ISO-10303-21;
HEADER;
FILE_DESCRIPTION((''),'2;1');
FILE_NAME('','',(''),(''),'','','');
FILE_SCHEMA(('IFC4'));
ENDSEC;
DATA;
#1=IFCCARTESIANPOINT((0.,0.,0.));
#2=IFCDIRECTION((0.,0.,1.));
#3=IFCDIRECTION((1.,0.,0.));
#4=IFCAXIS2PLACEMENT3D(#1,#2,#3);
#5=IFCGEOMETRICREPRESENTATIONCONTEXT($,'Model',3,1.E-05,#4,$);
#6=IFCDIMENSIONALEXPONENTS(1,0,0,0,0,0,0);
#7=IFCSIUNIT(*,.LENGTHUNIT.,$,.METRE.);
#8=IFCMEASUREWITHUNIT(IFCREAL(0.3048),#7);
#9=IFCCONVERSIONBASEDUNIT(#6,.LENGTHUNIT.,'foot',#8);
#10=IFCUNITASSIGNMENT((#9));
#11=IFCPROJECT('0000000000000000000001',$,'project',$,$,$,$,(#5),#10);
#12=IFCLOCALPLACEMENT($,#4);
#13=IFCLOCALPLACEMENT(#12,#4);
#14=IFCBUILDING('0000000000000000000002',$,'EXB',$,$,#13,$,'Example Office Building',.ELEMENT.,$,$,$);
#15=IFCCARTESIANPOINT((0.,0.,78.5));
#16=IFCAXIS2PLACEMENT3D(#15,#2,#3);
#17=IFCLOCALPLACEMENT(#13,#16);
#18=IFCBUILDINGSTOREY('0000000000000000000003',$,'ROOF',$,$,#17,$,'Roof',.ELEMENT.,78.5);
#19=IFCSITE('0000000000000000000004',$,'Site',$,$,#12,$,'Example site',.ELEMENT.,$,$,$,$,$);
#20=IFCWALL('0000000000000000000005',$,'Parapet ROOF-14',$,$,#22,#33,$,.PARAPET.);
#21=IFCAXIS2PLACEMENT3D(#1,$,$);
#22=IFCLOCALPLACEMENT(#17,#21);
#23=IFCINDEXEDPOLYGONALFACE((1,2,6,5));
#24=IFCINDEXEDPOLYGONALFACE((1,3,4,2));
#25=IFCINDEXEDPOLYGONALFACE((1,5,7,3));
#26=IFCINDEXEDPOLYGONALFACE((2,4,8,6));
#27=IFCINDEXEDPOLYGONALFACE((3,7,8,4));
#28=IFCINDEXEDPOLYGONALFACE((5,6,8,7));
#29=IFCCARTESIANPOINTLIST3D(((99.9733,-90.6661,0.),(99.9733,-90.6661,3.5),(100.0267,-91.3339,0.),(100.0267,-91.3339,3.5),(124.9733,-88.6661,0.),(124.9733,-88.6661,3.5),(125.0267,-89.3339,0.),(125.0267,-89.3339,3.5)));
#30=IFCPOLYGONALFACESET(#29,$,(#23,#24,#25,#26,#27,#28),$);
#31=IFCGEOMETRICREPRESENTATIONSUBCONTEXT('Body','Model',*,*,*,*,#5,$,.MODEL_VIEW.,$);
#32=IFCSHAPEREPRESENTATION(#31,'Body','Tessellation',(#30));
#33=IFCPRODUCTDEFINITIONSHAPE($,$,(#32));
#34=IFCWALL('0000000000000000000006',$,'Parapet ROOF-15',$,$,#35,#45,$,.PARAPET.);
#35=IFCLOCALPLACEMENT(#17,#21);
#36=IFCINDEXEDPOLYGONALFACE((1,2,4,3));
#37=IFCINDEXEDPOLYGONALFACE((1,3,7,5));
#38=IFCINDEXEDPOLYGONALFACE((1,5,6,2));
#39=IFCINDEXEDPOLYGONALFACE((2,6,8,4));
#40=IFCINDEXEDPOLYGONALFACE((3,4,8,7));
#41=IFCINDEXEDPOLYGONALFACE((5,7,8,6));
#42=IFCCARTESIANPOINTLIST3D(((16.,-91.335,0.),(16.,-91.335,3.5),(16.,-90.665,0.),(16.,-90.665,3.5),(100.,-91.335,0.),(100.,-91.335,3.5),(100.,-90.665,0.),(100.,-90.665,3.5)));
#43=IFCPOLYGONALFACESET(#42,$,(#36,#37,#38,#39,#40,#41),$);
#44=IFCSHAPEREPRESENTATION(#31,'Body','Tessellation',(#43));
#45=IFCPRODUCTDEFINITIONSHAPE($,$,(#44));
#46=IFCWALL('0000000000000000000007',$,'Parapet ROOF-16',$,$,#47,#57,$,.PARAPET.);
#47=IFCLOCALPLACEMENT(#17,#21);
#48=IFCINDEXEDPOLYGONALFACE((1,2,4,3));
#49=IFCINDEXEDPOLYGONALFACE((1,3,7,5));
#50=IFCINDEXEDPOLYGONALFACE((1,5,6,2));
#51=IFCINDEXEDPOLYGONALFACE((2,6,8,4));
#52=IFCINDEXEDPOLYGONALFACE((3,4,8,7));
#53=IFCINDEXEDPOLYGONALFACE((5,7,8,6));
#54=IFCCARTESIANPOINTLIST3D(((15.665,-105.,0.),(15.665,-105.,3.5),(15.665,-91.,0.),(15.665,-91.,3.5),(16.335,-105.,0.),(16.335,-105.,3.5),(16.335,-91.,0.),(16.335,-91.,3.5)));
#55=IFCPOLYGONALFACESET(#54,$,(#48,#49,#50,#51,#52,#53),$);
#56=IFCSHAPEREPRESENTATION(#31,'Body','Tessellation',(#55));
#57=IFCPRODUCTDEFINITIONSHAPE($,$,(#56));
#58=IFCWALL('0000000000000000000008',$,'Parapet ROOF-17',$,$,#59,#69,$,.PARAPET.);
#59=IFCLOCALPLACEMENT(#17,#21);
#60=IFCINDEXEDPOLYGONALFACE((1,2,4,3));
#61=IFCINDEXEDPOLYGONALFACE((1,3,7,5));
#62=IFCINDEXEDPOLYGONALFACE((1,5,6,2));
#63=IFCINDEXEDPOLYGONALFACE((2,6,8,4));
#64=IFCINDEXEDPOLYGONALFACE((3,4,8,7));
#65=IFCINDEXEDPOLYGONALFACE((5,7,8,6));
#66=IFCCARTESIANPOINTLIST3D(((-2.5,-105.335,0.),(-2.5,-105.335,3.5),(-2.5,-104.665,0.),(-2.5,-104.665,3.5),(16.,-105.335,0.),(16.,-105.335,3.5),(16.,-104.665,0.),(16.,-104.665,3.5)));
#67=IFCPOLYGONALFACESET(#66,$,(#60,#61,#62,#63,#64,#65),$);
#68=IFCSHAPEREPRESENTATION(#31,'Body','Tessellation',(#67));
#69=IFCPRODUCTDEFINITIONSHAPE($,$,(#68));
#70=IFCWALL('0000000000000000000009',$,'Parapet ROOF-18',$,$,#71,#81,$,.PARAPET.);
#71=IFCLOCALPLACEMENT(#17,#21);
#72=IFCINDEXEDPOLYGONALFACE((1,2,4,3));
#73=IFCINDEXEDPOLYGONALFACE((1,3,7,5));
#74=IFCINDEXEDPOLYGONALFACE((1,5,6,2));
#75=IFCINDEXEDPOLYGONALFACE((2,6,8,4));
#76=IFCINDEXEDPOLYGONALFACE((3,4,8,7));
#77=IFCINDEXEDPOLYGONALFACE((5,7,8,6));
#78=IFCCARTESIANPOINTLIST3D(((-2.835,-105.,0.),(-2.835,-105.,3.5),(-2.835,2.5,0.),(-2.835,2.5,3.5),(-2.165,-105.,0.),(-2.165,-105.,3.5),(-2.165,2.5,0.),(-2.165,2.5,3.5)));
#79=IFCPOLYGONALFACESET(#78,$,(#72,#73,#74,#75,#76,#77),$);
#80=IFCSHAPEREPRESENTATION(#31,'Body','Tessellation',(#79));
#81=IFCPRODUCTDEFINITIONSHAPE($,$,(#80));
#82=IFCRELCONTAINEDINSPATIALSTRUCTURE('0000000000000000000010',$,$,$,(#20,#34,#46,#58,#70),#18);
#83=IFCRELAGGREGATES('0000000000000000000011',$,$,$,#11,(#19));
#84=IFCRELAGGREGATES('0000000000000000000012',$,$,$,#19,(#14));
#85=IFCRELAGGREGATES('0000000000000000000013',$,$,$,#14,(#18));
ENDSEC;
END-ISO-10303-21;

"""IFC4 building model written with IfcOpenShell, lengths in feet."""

from ifc_helpers import new_model, entity, si_unit, converted_unit, frame, frame_2d, origin, origin_with_axes, place, context, subcontext, project, spatial, rectangle, extrude, element, save


model = new_model("IFC4")

# Units and contexts
model_context = context("Model", 3, precision=1e-05, world=origin_with_axes())
body_context = subcontext(model_context, "Body", "Model", "MODEL_VIEW")
ifc_project = project(units=[converted_unit("LENGTHUNIT", "foot", entity("IfcReal", 0.3048), si_unit("LENGTHUNIT", "METRE"), dimensions=[1, 0, 0, 0, 0, 0, 0])], contexts=[model_context])

# Site, building, storey
site_placement = place(None, origin_with_axes())
site = spatial("IfcSite", under=ifc_project, at=site_placement, Name="Site", LongName="Example site", CompositionType="ELEMENT")
building_placement = place(site_placement, origin_with_axes())
building = spatial("IfcBuilding", under=site, at=building_placement, Name="EXB", LongName="Example Office Building", CompositionType="ELEMENT")
storey_placement = place(building_placement, frame((0.0, 0.0, 78.5), z_axis=(0.0, 0.0, 1.0), x_axis=(1.0, 0.0, 0.0)))
storey = spatial("IfcBuildingStorey", under=building, at=storey_placement, Name="ROOF", LongName="Roof", CompositionType="ELEMENT", Elevation=78.5)

# Walls
wall_1_placement = place(storey_placement, frame((125.0, -89.0, 0.0), z_axis=(0.0, 0.0, 1.0), x_axis=(-0.996815, -0.079745, 0.0)))
element("IfcWall", 1, at=wall_1_placement, inside=storey, Name="Parapet ROOF-14", PredefinedType="PARAPET", context=body_context, shape_type="SweptSolid", body=[
    extrude(rectangle(XDim=25.0799, YDim=0.67, at=frame_2d((12.5399, 0.0))), origin(), (0.0, 0.0, 1.0), 3.5),
])
wall_2_placement = place(storey_placement, frame((100.0, -91.0, 0.0), z_axis=(0.0, 0.0, 1.0), x_axis=(-1.0, 0.0, 0.0)))
element("IfcWall", 2, at=wall_2_placement, inside=storey, Name="Parapet ROOF-15", PredefinedType="PARAPET", context=body_context, shape_type="SweptSolid", body=[
    extrude(rectangle(XDim=84.0, YDim=0.67, at=frame_2d((42.0, 0.0))), origin(), (0.0, 0.0, 1.0), 3.5),
])
wall_3_placement = place(storey_placement, frame((16.0, -91.0, 0.0), z_axis=(0.0, 0.0, 1.0), x_axis=(0.0, -1.0, 0.0)))
element("IfcWall", 3, at=wall_3_placement, inside=storey, Name="Parapet ROOF-16", PredefinedType="PARAPET", context=body_context, shape_type="SweptSolid", body=[
    extrude(rectangle(XDim=14.0, YDim=0.67, at=frame_2d((7.0, 0.0))), origin(), (0.0, 0.0, 1.0), 3.5),
])
wall_4_placement = place(storey_placement, frame((16.0, -105.0, 0.0), z_axis=(0.0, 0.0, 1.0), x_axis=(-1.0, 0.0, 0.0)))
element("IfcWall", 4, at=wall_4_placement, inside=storey, Name="Parapet ROOF-17", PredefinedType="PARAPET", context=body_context, shape_type="SweptSolid", body=[
    extrude(rectangle(XDim=18.5, YDim=0.67, at=frame_2d((9.25, 0.0))), origin(), (0.0, 0.0, 1.0), 3.5),
])
wall_5_placement = place(storey_placement, frame((-2.5, -105.0, 0.0), z_axis=(0.0, 0.0, 1.0), x_axis=(0.0, 1.0, 0.0)))
element("IfcWall", 5, at=wall_5_placement, inside=storey, Name="Parapet ROOF-18", PredefinedType="PARAPET", context=body_context, shape_type="SweptSolid", body=[
    extrude(rectangle(XDim=107.5, YDim=0.67, at=frame_2d((53.75, 0.0))), origin(), (0.0, 0.0, 1.0), 3.5),
])

save(model, "model.ifc")
